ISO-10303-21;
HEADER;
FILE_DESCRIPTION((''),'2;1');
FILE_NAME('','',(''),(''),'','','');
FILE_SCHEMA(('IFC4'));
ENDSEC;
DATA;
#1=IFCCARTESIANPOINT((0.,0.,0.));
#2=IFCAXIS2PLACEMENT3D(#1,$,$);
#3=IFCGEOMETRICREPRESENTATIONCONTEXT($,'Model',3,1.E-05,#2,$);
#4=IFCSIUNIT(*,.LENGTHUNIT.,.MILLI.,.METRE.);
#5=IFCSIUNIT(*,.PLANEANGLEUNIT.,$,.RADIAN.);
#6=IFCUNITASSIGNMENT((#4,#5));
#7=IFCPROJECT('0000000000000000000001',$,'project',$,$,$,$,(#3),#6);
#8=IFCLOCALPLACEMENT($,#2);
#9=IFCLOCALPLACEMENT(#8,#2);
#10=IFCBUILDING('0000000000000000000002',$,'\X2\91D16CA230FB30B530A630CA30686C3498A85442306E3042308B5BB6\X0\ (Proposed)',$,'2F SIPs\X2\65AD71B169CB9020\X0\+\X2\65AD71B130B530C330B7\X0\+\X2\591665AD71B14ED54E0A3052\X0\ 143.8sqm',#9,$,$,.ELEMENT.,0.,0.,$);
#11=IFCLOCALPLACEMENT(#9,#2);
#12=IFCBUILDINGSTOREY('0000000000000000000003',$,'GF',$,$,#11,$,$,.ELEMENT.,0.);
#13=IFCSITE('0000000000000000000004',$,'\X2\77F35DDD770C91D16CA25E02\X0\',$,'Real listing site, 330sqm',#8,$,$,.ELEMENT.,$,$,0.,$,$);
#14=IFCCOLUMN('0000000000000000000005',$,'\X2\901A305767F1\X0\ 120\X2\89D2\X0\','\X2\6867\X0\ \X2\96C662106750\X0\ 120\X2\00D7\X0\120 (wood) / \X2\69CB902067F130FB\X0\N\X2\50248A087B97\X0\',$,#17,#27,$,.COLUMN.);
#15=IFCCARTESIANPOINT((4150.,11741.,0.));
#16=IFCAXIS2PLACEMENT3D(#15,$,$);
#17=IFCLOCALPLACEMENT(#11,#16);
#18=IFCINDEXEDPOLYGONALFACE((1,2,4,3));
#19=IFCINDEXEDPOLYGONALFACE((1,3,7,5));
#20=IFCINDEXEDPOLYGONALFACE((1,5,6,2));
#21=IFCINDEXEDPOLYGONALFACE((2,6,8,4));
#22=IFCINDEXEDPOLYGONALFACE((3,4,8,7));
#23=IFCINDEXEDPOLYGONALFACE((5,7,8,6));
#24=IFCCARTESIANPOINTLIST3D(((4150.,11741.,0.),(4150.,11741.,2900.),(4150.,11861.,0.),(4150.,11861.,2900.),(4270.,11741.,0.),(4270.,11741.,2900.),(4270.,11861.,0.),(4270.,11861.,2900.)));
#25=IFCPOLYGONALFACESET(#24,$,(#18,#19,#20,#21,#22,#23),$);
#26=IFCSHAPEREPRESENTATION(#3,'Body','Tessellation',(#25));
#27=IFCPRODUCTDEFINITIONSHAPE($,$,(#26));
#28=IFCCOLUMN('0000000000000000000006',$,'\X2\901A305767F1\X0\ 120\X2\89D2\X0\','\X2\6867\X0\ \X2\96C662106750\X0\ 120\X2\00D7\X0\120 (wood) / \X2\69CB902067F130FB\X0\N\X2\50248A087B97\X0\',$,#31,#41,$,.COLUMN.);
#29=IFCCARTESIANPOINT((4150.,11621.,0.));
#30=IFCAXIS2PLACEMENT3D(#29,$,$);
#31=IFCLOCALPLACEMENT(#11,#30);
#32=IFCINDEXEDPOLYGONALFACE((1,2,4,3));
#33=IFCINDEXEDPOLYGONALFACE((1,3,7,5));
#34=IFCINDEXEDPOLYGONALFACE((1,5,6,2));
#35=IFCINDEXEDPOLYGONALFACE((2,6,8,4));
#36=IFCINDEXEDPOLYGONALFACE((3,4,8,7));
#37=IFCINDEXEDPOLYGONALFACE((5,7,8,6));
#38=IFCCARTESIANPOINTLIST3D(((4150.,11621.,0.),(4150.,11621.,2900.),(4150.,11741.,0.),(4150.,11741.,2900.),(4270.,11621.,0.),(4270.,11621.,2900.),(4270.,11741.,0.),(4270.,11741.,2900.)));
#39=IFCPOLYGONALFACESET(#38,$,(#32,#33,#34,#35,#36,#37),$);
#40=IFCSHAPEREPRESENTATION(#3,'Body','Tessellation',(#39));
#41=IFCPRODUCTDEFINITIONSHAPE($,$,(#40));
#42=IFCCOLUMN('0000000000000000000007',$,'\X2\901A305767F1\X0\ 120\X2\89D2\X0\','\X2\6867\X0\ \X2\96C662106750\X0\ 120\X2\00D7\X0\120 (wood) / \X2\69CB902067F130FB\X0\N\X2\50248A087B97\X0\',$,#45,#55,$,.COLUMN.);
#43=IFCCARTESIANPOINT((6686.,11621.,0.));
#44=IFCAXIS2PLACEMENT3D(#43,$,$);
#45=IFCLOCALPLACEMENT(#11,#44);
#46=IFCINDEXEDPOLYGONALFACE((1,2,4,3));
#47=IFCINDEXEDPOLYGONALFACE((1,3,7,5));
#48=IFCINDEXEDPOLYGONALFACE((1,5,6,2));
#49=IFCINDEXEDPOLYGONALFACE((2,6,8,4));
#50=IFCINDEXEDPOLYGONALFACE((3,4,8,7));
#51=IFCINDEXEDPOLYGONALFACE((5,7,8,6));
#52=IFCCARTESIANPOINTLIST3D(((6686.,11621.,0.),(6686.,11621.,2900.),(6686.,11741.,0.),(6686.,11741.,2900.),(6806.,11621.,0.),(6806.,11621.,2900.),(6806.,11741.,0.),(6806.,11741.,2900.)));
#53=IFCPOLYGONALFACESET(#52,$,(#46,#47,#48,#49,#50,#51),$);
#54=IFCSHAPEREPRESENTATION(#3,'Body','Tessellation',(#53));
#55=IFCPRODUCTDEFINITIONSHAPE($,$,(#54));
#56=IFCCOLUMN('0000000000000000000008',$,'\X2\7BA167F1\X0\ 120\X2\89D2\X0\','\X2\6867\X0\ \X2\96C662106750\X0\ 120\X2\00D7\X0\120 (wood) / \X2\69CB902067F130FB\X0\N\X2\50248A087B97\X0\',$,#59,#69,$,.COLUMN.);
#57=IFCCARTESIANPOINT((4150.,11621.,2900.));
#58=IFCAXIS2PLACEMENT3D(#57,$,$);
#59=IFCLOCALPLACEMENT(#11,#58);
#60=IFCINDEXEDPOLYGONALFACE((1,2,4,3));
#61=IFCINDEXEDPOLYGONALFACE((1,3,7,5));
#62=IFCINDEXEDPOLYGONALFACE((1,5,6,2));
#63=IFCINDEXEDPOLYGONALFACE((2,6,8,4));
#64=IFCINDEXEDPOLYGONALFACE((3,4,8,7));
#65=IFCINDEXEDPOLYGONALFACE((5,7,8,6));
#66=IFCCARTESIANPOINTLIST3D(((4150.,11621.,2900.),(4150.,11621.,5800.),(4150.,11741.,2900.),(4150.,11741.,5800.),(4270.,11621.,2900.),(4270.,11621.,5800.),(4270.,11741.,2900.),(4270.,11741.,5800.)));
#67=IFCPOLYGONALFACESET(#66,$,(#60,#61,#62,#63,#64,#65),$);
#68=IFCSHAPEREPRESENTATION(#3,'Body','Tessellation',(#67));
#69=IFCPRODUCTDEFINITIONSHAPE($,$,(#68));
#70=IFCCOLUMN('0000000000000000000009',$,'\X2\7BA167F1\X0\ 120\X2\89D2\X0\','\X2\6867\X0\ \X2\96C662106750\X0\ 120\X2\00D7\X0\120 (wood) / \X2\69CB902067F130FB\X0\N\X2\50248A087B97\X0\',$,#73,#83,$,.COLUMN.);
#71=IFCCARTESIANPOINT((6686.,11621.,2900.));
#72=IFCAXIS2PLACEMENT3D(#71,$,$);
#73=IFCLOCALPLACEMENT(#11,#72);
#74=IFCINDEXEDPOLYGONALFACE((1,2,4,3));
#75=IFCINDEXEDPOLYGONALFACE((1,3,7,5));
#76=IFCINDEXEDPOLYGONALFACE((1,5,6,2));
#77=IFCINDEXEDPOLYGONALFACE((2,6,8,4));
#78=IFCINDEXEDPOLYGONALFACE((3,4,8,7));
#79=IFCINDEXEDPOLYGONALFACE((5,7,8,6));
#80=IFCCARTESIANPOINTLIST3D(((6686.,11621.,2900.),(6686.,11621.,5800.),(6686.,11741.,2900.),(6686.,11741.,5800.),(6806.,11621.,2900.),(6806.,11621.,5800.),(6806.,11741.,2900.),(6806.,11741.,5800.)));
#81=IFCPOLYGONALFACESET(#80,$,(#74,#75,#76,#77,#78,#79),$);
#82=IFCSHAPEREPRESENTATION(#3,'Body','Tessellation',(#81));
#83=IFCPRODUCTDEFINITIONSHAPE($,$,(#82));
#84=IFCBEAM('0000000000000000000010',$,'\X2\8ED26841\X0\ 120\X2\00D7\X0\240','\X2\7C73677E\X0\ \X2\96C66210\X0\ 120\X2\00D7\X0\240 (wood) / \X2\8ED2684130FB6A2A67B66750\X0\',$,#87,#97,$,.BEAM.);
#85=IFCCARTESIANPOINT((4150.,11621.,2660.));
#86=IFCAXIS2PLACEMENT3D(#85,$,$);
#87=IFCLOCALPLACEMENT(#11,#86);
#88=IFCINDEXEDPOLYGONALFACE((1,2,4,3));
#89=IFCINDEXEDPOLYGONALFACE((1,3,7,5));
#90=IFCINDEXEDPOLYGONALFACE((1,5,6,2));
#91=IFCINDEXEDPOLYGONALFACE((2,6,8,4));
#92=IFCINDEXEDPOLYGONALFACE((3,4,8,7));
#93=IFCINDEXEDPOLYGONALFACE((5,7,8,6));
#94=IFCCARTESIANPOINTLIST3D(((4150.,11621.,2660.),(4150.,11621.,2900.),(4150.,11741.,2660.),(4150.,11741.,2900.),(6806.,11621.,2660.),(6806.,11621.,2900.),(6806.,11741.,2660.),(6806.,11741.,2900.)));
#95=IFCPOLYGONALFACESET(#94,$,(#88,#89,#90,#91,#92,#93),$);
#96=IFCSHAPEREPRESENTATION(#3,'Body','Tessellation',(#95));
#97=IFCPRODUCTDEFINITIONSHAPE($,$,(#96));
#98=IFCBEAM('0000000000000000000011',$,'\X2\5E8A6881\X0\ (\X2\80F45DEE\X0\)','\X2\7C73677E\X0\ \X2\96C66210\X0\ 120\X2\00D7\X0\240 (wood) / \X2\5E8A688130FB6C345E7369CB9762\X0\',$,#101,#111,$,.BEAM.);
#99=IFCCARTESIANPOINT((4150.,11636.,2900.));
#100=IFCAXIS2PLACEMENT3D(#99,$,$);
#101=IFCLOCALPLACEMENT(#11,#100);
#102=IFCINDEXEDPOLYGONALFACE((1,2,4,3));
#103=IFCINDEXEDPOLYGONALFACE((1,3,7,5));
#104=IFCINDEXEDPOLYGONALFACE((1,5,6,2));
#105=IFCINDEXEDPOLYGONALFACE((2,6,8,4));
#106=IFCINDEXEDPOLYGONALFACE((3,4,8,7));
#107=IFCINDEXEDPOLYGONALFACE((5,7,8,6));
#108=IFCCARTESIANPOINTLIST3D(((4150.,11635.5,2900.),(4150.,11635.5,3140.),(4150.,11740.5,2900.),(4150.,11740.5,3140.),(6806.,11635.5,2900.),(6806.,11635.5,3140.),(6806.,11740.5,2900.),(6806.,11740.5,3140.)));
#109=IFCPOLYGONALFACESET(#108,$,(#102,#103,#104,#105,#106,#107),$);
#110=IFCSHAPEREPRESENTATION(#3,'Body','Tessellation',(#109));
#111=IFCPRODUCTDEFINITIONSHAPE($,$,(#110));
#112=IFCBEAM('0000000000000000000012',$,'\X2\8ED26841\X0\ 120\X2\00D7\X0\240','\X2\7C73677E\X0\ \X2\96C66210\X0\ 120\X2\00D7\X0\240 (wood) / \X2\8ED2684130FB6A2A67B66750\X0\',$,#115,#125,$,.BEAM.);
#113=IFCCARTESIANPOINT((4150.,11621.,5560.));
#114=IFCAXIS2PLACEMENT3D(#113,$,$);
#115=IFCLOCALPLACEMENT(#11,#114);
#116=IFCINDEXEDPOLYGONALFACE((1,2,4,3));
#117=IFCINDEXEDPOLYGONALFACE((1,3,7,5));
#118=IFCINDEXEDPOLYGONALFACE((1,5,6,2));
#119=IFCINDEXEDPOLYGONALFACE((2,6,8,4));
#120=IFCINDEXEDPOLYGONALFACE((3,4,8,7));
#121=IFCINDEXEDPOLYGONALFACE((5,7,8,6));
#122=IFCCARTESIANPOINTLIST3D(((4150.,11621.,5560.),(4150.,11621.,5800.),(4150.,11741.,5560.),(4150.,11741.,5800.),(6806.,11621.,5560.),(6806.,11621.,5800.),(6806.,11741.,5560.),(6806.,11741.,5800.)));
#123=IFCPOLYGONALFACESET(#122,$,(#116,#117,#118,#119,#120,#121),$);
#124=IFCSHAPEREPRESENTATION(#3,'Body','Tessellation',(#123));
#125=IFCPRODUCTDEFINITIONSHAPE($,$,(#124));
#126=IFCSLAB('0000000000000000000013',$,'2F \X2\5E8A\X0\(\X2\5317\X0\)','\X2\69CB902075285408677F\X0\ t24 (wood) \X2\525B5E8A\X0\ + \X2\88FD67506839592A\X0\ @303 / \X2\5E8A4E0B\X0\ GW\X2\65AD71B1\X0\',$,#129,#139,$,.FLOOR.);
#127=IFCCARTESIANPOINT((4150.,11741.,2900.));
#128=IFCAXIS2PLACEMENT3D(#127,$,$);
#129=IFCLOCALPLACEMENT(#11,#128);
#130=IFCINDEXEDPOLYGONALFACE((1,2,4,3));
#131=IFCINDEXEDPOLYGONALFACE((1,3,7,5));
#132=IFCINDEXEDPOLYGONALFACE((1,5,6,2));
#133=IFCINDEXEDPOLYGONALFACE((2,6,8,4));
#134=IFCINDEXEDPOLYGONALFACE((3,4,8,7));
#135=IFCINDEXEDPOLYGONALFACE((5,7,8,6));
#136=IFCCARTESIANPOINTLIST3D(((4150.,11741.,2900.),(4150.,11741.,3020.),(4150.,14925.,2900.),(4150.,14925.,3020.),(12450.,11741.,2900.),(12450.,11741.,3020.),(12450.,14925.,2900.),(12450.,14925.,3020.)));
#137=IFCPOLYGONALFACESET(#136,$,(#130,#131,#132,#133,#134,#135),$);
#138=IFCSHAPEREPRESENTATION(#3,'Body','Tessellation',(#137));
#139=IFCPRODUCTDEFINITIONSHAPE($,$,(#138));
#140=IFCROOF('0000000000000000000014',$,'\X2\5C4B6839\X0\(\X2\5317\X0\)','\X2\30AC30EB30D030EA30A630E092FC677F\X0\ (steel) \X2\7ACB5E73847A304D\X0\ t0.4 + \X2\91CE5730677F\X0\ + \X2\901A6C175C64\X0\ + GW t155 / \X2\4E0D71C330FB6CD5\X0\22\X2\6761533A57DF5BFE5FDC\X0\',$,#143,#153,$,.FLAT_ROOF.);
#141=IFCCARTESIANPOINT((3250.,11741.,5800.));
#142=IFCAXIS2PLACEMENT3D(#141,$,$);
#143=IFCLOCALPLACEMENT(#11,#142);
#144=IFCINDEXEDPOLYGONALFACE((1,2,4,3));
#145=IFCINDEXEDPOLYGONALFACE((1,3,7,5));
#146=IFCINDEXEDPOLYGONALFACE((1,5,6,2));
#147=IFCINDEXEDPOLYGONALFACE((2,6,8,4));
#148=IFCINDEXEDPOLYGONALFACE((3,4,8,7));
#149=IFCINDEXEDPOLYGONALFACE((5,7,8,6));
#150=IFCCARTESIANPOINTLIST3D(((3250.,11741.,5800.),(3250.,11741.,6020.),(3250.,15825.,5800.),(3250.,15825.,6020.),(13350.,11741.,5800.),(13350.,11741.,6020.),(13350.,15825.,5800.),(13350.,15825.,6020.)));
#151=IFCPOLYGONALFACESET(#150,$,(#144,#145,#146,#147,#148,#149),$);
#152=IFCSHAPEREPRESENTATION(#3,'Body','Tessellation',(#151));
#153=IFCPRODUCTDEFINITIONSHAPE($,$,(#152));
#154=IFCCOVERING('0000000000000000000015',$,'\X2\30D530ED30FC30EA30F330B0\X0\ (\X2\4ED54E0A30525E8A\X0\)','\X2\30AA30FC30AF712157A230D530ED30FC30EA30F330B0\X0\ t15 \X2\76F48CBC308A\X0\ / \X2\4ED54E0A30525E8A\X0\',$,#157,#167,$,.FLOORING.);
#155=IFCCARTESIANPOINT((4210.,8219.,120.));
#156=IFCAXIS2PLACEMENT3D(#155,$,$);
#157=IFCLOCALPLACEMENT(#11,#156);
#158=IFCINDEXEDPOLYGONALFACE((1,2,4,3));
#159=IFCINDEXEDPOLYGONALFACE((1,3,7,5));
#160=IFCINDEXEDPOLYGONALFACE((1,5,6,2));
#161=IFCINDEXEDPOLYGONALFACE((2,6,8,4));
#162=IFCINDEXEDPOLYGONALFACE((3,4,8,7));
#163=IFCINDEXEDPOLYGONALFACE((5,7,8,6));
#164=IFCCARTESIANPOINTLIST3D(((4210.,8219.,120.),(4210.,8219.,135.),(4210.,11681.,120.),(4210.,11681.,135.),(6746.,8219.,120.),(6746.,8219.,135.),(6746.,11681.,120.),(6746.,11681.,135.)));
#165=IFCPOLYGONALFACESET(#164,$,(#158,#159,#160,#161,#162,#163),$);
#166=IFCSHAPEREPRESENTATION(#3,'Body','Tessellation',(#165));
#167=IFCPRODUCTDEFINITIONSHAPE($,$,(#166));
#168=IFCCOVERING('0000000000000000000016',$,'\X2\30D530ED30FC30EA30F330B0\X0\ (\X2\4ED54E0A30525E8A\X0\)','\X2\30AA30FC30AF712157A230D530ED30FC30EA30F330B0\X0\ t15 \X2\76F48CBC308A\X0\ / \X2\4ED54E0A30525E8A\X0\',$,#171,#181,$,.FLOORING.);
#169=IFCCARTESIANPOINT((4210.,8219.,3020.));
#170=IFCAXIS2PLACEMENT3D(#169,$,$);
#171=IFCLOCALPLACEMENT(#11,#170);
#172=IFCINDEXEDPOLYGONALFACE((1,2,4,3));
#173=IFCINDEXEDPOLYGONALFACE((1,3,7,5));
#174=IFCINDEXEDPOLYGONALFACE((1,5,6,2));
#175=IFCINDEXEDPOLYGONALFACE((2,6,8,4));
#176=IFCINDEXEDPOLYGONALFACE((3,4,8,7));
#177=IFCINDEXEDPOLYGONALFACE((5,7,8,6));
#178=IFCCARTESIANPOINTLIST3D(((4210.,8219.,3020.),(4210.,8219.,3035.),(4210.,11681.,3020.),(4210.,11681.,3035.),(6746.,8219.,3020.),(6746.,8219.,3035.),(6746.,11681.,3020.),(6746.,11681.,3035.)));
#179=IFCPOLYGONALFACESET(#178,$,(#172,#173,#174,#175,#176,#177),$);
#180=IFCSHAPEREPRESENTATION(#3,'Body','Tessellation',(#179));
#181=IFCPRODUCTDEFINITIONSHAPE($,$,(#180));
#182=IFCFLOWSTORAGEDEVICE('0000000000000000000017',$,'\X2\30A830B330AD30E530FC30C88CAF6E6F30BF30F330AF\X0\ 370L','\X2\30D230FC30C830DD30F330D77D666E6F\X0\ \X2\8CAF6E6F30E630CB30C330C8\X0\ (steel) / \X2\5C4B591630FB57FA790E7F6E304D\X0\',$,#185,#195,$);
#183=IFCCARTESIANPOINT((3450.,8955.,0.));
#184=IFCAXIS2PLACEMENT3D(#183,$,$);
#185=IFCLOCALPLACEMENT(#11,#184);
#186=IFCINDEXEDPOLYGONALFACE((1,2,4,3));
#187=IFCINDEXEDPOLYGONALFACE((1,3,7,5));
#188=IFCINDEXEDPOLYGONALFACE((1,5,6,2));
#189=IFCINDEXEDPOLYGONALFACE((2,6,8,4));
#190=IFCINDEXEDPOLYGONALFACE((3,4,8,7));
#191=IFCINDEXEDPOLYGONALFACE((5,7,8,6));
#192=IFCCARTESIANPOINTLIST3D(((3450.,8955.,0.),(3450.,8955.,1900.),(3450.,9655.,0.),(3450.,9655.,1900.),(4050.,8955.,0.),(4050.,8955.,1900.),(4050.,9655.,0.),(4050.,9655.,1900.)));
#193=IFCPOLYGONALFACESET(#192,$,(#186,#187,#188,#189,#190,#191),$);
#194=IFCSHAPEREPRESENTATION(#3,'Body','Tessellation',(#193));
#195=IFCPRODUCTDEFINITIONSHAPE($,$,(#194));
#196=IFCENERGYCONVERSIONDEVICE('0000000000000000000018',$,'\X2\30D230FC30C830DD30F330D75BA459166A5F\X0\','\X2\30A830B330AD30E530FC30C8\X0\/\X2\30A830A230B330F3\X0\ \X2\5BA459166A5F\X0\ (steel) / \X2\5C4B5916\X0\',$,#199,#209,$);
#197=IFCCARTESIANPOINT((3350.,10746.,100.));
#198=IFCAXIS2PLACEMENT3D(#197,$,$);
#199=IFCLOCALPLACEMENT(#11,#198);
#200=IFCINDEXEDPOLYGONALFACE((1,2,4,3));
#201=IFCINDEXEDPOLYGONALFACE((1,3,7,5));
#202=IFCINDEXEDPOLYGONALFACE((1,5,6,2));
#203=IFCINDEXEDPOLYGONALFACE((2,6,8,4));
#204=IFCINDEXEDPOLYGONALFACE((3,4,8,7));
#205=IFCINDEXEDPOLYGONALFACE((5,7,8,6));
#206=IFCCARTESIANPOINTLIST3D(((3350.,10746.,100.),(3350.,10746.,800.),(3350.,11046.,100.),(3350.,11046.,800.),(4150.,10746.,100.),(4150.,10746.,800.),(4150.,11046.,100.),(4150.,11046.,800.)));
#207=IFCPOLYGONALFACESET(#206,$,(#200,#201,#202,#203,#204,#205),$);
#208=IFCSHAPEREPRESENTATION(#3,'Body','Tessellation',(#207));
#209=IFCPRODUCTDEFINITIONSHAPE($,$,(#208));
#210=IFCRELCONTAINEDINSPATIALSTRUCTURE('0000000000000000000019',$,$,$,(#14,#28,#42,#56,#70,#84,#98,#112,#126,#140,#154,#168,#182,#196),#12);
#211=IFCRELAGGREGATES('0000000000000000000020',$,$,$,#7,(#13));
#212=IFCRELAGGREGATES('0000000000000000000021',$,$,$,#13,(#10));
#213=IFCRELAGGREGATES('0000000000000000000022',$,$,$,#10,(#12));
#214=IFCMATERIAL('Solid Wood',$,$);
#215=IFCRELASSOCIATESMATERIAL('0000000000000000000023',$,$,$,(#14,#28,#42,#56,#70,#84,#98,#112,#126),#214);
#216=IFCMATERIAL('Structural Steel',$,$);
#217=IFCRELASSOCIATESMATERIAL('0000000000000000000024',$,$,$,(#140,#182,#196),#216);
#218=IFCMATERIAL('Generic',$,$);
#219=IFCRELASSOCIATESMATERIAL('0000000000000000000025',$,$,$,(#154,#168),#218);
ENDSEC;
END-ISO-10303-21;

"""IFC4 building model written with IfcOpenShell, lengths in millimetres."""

from ifc_helpers import new_model, si_unit, frame, frame_2d, origin, place, context, project, spatial, rectangle, extrude, material, element, save


model = new_model("IFC4")

# Units and contexts
model_context = context("Model", 3, precision=1e-05, world=origin())
ifc_project = project(units=[si_unit("LENGTHUNIT", "METRE", prefix="MILLI"), si_unit("PLANEANGLEUNIT", "RADIAN")], contexts=[model_context])

# Site, building, storey
site_placement = place(None, origin())
site = spatial("IfcSite", under=ifc_project, at=site_placement, Name="石川県金沢市", ObjectType="Real listing site, 330sqm", CompositionType="ELEMENT", RefElevation=0.0)
building_placement = place(site_placement, origin())
building = spatial("IfcBuilding", under=site, at=building_placement, Name="金沢・サウナと水風呂のある家 (Proposed)", ObjectType="2F SIPs断熱構造+断熱サッシ+外断熱仕上げ 143.8sqm", CompositionType="ELEMENT", ElevationOfRefHeight=0.0, ElevationOfTerrain=0.0)
storey_placement = place(building_placement, origin())
storey = spatial("IfcBuildingStorey", under=building, at=storey_placement, Name="GF", CompositionType="ELEMENT", Elevation=0.0)

# Columns
ifc_material_1 = material(Name="Solid Wood")
column_1_placement = place(storey_placement, frame((4150.0, 11741.0, 0.0)))
element("IfcColumn", 1, at=column_1_placement, inside=storey, material=ifc_material_1, Name="通し柱 120角", Description="桧 集成材 120×120 (wood) / 構造柱・N値計算", PredefinedType="COLUMN", context=model_context, shape_type="SweptSolid", body=[
    extrude(rectangle(XDim=120.0, YDim=120.0, at=frame_2d((60.0, 60.0))), frame((4150.0, 11741.0, 0.0)), (0.0, 0.0, 1.0), 2900.0),
])
column_2_placement = place(storey_placement, frame((4150.0, 11621.0, 0.0)))
element("IfcColumn", 2, at=column_2_placement, inside=storey, material=ifc_material_1, Name="通し柱 120角", Description="桧 集成材 120×120 (wood) / 構造柱・N値計算", PredefinedType="COLUMN", context=model_context, shape_type="SweptSolid", body=[
    extrude(rectangle(XDim=120.0, YDim=120.0, at=frame_2d((60.0, 60.0))), frame((4150.0, 11621.0, 0.0)), (0.0, 0.0, 1.0), 2900.0),
])
column_3_placement = place(storey_placement, frame((6686.0, 11621.0, 0.0)))
element("IfcColumn", 3, at=column_3_placement, inside=storey, material=ifc_material_1, Name="通し柱 120角", Description="桧 集成材 120×120 (wood) / 構造柱・N値計算", PredefinedType="COLUMN", context=model_context, shape_type="SweptSolid", body=[
    extrude(rectangle(XDim=120.0, YDim=120.0, at=frame_2d((60.0, 60.0))), frame((6686.0, 11621.0, 0.0)), (0.0, 0.0, 1.0), 2900.0),
])
column_4_placement = place(storey_placement, frame((4150.0, 11621.0, 2900.0)))
element("IfcColumn", 4, at=column_4_placement, inside=storey, material=ifc_material_1, Name="管柱 120角", Description="桧 集成材 120×120 (wood) / 構造柱・N値計算", PredefinedType="COLUMN", context=model_context, shape_type="SweptSolid", body=[
    extrude(rectangle(XDim=120.0, YDim=120.0, at=frame_2d((60.0, 60.0))), frame((4150.0, 11621.0, 2900.0)), (0.0, 0.0, 1.0), 2900.0),
])
column_5_placement = place(storey_placement, frame((6686.0, 11621.0, 2900.0)))
element("IfcColumn", 5, at=column_5_placement, inside=storey, material=ifc_material_1, Name="管柱 120角", Description="桧 集成材 120×120 (wood) / 構造柱・N値計算", PredefinedType="COLUMN", context=model_context, shape_type="SweptSolid", body=[
    extrude(rectangle(XDim=120.0, YDim=120.0, at=frame_2d((60.0, 60.0))), frame((6686.0, 11621.0, 2900.0)), (0.0, 0.0, 1.0), 2900.0),
])

# Beams
beam_1_placement = place(storey_placement, frame((4150.0, 11621.0, 2660.0)))
element("IfcBeam", 6, at=beam_1_placement, inside=storey, material=ifc_material_1, Name="軒桁 120×240", Description="米松 集成 120×240 (wood) / 軒桁・横架材", PredefinedType="BEAM", context=model_context, shape_type="SweptSolid", body=[
    extrude(rectangle(XDim=2656.0, YDim=120.0, at=frame_2d((1328.0, 60.0))), frame((4150.0, 11621.0, 2660.0)), (0.0, 0.0, 1.0), 240.0),
])
beam_2_placement = place(storey_placement, frame((4150.0, 11636.0, 2900.0)))
element("IfcBeam", 7, at=beam_2_placement, inside=storey, material=ifc_material_1, Name="床梁 (胴差)", Description="米松 集成 120×240 (wood) / 床梁・水平構面", PredefinedType="BEAM", context=model_context, shape_type="SweptSolid", body=[
    extrude(rectangle(XDim=2656.0, YDim=105.0, at=frame_2d((1328.0, 52.0))), frame((4150.0, 11636.0, 2900.0)), (0.0, 0.0, 1.0), 240.0),
])
beam_3_placement = place(storey_placement, frame((4150.0, 11621.0, 5560.0)))
element("IfcBeam", 8, at=beam_3_placement, inside=storey, material=ifc_material_1, Name="軒桁 120×240", Description="米松 集成 120×240 (wood) / 軒桁・横架材", PredefinedType="BEAM", context=model_context, shape_type="SweptSolid", body=[
    extrude(rectangle(XDim=2656.0, YDim=120.0, at=frame_2d((1328.0, 60.0))), frame((4150.0, 11621.0, 5560.0)), (0.0, 0.0, 1.0), 240.0),
])

# Slab
slab_1_placement = place(storey_placement, frame((4150.0, 11741.0, 2900.0)))
element("IfcSlab", 9, at=slab_1_placement, inside=storey, material=ifc_material_1, Name="2F 床(北)", Description="構造用合板 t24 (wood) 剛床 + 製材根太 @303 / 床下 GW断熱", PredefinedType="FLOOR", context=model_context, shape_type="SweptSolid", body=[
    extrude(rectangle(XDim=8300.0, YDim=3184.0, at=frame_2d((4150.0, 1592.0))), frame((4150.0, 11741.0, 2900.0)), (0.0, 0.0, 1.0), 120.0),
])

# Roof
ifc_material_2 = material(Name="Structural Steel")
for number, where, name in (
    (10, (3250.0, 11741.0, 5800.0), "屋根(北)"),
):
    element("IfcRoof", number, at=place(storey_placement, frame(where)), inside=storey, material=ifc_material_2, Name=name, Description="ガルバリウム鋼板 (steel) 立平葺き t0.4 + 野地板 + 通気層 + GW t155 / 不燃・法22条区域対応", PredefinedType="FLAT_ROOF", context=model_context, shape_type="SweptSolid", body=[
        extrude(rectangle(XDim=10100.0, YDim=4084.0, at=frame_2d((5050.0, 2042.0))), frame((3250.0, 11741.0, 5800.0)), (0.0, 0.0, 1.0), 220.0),
    ])

# Coverings
ifc_material_3 = material(Name="Generic")
covering_1_placement = place(storey_placement, frame((4210.0, 8219.0, 120.0)))
element("IfcCovering", 11, at=covering_1_placement, inside=storey, material=ifc_material_3, Name="フローリング (仕上げ床)", Description="オーク無垢フローリング t15 直貼り / 仕上げ床", PredefinedType="FLOORING", context=model_context, shape_type="SweptSolid", body=[
    extrude(rectangle(XDim=2536.0, YDim=3462.0, at=frame_2d((1268.0, 1731.0))), frame((4210.0, 8219.0, 120.0)), (0.0, 0.0, 1.0), 15.0),
])
covering_2_placement = place(storey_placement, frame((4210.0, 8219.0, 3020.0)))
element("IfcCovering", 12, at=covering_2_placement, inside=storey, material=ifc_material_3, Name="フローリング (仕上げ床)", Description="オーク無垢フローリング t15 直貼り / 仕上げ床", PredefinedType="FLOORING", context=model_context, shape_type="SweptSolid", body=[
    extrude(rectangle(XDim=2536.0, YDim=3462.0, at=frame_2d((1268.0, 1731.0))), frame((4210.0, 8219.0, 3020.0)), (0.0, 0.0, 1.0), 15.0),
])

# Flow storage device
flow_storage_device_placement = place(storey_placement, frame((3450.0, 8955.0, 0.0)))
element("IfcFlowStorageDevice", 13, at=flow_storage_device_placement, inside=storey, material=ifc_material_2, Name="エコキュート貯湯タンク 370L", Description="ヒートポンプ給湯 貯湯ユニット (steel) / 屋外・基礎置き", context=model_context, shape_type="SweptSolid", body=[
    extrude(rectangle(XDim=600.0, YDim=700.0, at=frame_2d((300.0, 350.0))), frame((3450.0, 8955.0, 0.0)), (0.0, 0.0, 1.0), 1900.0),
])

# Energy conversion device
energy_conversion_device_placement = place(storey_placement, frame((3350.0, 10746.0, 100.0)))
element("IfcEnergyConversionDevice", 14, at=energy_conversion_device_placement, inside=storey, material=ifc_material_2, Name="ヒートポンプ室外機", Description="エコキュート/エアコン 室外機 (steel) / 屋外", context=model_context, shape_type="SweptSolid", body=[
    extrude(rectangle(XDim=800.0, YDim=300.0, at=frame_2d((400.0, 150.0))), frame((3350.0, 10746.0, 100.0)), (0.0, 0.0, 1.0), 700.0),
])

save(model, "model.ifc")
